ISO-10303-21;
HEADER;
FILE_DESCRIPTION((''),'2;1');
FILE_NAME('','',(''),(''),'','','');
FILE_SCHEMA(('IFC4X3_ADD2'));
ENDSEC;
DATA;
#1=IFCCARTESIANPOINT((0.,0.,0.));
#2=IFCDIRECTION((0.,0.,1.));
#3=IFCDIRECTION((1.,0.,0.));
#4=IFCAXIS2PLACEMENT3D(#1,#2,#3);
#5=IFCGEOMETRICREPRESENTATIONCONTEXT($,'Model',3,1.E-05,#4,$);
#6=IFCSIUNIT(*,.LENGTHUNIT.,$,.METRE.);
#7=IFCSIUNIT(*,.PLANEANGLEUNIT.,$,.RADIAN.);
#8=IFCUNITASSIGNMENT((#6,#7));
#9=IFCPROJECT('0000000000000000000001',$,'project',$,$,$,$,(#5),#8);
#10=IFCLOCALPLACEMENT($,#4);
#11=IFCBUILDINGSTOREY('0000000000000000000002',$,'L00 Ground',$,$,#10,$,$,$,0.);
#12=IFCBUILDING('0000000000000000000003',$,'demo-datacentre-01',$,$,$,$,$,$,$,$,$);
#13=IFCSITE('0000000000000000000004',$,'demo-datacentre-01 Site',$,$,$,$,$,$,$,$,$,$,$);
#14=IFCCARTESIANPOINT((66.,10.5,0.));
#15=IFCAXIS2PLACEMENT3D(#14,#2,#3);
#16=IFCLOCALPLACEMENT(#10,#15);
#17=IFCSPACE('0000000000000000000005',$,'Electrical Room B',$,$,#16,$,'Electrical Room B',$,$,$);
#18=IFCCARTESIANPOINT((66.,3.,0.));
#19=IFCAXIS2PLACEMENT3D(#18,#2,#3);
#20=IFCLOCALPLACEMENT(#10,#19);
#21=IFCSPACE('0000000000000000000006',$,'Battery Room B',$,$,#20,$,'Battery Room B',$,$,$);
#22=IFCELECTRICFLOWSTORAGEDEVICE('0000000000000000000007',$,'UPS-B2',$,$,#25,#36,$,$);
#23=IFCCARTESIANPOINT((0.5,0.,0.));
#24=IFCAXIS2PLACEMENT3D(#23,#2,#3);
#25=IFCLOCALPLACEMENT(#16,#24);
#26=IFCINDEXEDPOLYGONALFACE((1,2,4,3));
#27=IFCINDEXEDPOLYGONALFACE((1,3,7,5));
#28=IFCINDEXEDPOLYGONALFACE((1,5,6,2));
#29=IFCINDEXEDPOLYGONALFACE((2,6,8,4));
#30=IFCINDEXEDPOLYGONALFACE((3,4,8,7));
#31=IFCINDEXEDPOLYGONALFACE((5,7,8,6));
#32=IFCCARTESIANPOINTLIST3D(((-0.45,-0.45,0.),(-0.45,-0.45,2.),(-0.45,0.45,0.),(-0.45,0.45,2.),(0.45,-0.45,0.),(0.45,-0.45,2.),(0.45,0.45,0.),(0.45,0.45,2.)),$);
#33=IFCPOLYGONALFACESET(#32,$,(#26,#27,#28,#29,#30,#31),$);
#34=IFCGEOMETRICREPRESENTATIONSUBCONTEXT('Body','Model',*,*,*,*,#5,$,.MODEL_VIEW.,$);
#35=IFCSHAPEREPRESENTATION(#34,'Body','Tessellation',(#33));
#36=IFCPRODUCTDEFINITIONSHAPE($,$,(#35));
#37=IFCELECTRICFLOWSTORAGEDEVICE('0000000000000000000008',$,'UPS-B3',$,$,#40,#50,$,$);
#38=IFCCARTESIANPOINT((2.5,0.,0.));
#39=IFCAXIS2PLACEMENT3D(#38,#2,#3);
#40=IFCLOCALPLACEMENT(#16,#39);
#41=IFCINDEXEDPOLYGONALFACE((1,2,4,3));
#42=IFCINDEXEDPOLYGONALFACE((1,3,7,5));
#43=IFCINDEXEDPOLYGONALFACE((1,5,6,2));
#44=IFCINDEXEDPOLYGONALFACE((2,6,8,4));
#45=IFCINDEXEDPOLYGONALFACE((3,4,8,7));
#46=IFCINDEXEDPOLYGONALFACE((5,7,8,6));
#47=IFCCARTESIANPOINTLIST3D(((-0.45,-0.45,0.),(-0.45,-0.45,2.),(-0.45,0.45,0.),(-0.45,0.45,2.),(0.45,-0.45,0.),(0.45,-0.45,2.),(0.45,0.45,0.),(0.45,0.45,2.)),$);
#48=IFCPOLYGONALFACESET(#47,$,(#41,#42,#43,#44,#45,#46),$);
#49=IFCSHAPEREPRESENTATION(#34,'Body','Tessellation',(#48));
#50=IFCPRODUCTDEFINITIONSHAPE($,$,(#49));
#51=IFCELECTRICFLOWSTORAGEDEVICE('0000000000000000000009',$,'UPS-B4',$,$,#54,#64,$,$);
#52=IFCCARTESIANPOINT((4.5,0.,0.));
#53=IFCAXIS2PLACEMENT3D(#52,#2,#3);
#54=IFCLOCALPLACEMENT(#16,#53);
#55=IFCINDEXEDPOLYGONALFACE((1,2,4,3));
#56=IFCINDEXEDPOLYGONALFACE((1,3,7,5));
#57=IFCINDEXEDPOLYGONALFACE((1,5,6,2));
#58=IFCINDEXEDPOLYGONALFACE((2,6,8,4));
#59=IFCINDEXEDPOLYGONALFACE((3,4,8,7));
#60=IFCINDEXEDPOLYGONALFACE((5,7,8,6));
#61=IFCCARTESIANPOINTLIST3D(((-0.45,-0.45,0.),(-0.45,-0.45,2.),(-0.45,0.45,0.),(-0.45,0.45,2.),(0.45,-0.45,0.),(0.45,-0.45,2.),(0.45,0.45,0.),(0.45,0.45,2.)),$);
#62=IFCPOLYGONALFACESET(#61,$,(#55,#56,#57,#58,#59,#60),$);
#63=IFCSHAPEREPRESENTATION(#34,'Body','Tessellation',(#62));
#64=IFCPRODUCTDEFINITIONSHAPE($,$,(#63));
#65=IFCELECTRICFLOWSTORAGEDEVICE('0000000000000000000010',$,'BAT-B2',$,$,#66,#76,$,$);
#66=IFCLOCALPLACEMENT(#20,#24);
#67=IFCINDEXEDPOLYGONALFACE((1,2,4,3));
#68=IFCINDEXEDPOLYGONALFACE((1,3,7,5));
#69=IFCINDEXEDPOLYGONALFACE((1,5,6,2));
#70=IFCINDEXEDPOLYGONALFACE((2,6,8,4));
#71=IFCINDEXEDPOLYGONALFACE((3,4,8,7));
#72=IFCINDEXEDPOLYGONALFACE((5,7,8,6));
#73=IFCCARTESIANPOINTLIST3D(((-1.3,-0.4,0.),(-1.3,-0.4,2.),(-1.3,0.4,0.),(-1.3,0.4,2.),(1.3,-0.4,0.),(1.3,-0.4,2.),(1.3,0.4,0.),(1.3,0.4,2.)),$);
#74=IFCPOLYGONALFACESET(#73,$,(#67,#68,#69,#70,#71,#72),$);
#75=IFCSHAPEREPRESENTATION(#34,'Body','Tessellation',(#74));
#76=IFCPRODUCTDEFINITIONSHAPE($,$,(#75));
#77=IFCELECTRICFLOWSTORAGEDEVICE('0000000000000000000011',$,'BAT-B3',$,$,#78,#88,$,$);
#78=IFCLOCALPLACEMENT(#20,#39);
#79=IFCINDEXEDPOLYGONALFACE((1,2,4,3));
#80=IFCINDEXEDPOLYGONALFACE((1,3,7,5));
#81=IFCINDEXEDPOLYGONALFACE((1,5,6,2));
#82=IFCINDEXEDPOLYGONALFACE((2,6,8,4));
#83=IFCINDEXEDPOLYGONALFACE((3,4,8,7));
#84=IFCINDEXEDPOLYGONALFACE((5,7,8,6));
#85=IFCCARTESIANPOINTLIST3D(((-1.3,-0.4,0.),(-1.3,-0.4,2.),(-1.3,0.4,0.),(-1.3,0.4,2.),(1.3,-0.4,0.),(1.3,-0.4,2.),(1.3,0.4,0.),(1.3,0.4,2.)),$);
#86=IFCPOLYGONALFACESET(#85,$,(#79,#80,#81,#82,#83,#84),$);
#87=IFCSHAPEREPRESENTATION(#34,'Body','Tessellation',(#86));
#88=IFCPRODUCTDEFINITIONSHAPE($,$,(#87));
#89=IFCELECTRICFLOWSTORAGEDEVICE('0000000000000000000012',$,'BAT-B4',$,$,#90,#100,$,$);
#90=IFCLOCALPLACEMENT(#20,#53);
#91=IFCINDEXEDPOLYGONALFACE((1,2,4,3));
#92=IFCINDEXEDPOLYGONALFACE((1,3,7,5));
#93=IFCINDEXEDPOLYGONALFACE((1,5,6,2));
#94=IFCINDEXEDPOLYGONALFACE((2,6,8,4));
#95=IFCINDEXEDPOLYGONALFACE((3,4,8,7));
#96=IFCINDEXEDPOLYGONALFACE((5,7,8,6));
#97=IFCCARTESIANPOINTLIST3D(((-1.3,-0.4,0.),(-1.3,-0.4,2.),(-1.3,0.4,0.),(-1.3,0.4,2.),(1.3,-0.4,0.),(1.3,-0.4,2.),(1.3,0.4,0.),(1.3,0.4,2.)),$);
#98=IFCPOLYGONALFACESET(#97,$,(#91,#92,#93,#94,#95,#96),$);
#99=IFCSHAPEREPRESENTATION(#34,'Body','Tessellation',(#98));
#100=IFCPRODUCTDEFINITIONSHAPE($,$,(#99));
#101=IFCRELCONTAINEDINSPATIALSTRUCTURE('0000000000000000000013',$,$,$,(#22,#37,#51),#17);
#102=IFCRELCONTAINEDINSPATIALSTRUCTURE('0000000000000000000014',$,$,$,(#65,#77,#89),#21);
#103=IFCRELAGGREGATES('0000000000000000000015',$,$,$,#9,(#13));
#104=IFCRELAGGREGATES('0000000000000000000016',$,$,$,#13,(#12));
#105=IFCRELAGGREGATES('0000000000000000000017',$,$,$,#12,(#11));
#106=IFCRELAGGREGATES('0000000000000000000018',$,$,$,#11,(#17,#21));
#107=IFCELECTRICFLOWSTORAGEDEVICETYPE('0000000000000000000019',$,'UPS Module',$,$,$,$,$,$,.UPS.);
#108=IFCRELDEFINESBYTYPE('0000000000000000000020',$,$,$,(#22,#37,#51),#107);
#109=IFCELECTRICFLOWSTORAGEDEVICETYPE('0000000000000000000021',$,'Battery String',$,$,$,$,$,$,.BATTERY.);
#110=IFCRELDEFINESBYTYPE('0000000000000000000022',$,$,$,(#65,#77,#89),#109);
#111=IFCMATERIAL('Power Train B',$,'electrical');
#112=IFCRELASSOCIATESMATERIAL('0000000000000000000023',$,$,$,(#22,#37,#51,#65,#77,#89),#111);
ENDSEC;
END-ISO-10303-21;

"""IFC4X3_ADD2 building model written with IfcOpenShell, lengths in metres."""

from ifc_helpers import new_model, si_unit, frame, origin_with_axes, place, context, subcontext, project, spatial, rectangle, extrude, material, type_object, element, save


model = new_model("IFC4X3_ADD2")

# Units and contexts
model_context = context("Model", 3, precision=1e-05, world=origin_with_axes())
body_context = subcontext(model_context, "Body", "Model", "MODEL_VIEW")
ifc_project = project(units=[si_unit("LENGTHUNIT", "METRE"), si_unit("PLANEANGLEUNIT", "RADIAN")], contexts=[model_context])

# Site, building, storey, space
site = spatial("IfcSite", under=ifc_project, Name="demo-datacentre-01 Site")
building = spatial("IfcBuilding", under=site, Name="demo-datacentre-01")
storey_placement = place(None, origin_with_axes())
storey = spatial("IfcBuildingStorey", under=building, at=storey_placement, Name="L00 Ground", Elevation=0.0)
space_1_placement = place(storey_placement, frame((66.0, 10.5, 0.0), z_axis=(0.0, 0.0, 1.0), x_axis=(1.0, 0.0, 0.0)))
space_1 = spatial("IfcSpace", under=storey, at=space_1_placement, Name="Electrical Room B", LongName="Electrical Room B")

# Shared definitions
ifc_material = material(Name="Power Train B", Category="electrical")

# Electric flow storage devices
electric_flow_storage_device_type_1 = type_object("IfcElectricFlowStorageDeviceType", Name="UPS Module", PredefinedType="UPS")
for number, where, z_axis, x_axis, name in (
    (1, (0.5, 0.0, 0.0), (0.0, 0.0, 1.0), (1.0, 0.0, 0.0), "UPS-B2"),
    (2, (2.5, 0.0, 0.0), (0.0, 0.0, 1.0), (1.0, 0.0, 0.0), "UPS-B3"),
    (3, (4.5, 0.0, 0.0), (0.0, 0.0, 1.0), (1.0, 0.0, 0.0), "UPS-B4"),
):
    element("IfcElectricFlowStorageDevice", number, at=place(space_1_placement, frame(where, z_axis=z_axis, x_axis=x_axis)), inside=space_1, type_object=electric_flow_storage_device_type_1, material=ifc_material, Name=name, context=body_context, shape_type="SweptSolid", body=[
        extrude(rectangle(XDim=0.9, YDim=0.9), origin_with_axes(), (0.0, 0.0, 1.0), 2.0),
    ])

# Shared definitions
space_2_placement = place(storey_placement, frame((66.0, 3.0, 0.0), z_axis=(0.0, 0.0, 1.0), x_axis=(1.0, 0.0, 0.0)))
space_2 = spatial("IfcSpace", under=storey, at=space_2_placement, Name="Battery Room B", LongName="Battery Room B")

# Electric flow storage devices
electric_flow_storage_device_type_2 = type_object("IfcElectricFlowStorageDeviceType", Name="Battery String", PredefinedType="BATTERY")
for number, where, z_axis, x_axis, name in (
    (4, (0.5, 0.0, 0.0), (0.0, 0.0, 1.0), (1.0, 0.0, 0.0), "BAT-B2"),
    (5, (2.5, 0.0, 0.0), (0.0, 0.0, 1.0), (1.0, 0.0, 0.0), "BAT-B3"),
    (6, (4.5, 0.0, 0.0), (0.0, 0.0, 1.0), (1.0, 0.0, 0.0), "BAT-B4"),
):
    element("IfcElectricFlowStorageDevice", number, at=place(space_2_placement, frame(where, z_axis=z_axis, x_axis=x_axis)), inside=space_2, type_object=electric_flow_storage_device_type_2, material=ifc_material, Name=name, context=body_context, shape_type="SweptSolid", body=[
        extrude(rectangle(XDim=2.6, YDim=0.8), origin_with_axes(), (0.0, 0.0, 1.0), 2.0),
    ])

save(model, "model.ifc")
